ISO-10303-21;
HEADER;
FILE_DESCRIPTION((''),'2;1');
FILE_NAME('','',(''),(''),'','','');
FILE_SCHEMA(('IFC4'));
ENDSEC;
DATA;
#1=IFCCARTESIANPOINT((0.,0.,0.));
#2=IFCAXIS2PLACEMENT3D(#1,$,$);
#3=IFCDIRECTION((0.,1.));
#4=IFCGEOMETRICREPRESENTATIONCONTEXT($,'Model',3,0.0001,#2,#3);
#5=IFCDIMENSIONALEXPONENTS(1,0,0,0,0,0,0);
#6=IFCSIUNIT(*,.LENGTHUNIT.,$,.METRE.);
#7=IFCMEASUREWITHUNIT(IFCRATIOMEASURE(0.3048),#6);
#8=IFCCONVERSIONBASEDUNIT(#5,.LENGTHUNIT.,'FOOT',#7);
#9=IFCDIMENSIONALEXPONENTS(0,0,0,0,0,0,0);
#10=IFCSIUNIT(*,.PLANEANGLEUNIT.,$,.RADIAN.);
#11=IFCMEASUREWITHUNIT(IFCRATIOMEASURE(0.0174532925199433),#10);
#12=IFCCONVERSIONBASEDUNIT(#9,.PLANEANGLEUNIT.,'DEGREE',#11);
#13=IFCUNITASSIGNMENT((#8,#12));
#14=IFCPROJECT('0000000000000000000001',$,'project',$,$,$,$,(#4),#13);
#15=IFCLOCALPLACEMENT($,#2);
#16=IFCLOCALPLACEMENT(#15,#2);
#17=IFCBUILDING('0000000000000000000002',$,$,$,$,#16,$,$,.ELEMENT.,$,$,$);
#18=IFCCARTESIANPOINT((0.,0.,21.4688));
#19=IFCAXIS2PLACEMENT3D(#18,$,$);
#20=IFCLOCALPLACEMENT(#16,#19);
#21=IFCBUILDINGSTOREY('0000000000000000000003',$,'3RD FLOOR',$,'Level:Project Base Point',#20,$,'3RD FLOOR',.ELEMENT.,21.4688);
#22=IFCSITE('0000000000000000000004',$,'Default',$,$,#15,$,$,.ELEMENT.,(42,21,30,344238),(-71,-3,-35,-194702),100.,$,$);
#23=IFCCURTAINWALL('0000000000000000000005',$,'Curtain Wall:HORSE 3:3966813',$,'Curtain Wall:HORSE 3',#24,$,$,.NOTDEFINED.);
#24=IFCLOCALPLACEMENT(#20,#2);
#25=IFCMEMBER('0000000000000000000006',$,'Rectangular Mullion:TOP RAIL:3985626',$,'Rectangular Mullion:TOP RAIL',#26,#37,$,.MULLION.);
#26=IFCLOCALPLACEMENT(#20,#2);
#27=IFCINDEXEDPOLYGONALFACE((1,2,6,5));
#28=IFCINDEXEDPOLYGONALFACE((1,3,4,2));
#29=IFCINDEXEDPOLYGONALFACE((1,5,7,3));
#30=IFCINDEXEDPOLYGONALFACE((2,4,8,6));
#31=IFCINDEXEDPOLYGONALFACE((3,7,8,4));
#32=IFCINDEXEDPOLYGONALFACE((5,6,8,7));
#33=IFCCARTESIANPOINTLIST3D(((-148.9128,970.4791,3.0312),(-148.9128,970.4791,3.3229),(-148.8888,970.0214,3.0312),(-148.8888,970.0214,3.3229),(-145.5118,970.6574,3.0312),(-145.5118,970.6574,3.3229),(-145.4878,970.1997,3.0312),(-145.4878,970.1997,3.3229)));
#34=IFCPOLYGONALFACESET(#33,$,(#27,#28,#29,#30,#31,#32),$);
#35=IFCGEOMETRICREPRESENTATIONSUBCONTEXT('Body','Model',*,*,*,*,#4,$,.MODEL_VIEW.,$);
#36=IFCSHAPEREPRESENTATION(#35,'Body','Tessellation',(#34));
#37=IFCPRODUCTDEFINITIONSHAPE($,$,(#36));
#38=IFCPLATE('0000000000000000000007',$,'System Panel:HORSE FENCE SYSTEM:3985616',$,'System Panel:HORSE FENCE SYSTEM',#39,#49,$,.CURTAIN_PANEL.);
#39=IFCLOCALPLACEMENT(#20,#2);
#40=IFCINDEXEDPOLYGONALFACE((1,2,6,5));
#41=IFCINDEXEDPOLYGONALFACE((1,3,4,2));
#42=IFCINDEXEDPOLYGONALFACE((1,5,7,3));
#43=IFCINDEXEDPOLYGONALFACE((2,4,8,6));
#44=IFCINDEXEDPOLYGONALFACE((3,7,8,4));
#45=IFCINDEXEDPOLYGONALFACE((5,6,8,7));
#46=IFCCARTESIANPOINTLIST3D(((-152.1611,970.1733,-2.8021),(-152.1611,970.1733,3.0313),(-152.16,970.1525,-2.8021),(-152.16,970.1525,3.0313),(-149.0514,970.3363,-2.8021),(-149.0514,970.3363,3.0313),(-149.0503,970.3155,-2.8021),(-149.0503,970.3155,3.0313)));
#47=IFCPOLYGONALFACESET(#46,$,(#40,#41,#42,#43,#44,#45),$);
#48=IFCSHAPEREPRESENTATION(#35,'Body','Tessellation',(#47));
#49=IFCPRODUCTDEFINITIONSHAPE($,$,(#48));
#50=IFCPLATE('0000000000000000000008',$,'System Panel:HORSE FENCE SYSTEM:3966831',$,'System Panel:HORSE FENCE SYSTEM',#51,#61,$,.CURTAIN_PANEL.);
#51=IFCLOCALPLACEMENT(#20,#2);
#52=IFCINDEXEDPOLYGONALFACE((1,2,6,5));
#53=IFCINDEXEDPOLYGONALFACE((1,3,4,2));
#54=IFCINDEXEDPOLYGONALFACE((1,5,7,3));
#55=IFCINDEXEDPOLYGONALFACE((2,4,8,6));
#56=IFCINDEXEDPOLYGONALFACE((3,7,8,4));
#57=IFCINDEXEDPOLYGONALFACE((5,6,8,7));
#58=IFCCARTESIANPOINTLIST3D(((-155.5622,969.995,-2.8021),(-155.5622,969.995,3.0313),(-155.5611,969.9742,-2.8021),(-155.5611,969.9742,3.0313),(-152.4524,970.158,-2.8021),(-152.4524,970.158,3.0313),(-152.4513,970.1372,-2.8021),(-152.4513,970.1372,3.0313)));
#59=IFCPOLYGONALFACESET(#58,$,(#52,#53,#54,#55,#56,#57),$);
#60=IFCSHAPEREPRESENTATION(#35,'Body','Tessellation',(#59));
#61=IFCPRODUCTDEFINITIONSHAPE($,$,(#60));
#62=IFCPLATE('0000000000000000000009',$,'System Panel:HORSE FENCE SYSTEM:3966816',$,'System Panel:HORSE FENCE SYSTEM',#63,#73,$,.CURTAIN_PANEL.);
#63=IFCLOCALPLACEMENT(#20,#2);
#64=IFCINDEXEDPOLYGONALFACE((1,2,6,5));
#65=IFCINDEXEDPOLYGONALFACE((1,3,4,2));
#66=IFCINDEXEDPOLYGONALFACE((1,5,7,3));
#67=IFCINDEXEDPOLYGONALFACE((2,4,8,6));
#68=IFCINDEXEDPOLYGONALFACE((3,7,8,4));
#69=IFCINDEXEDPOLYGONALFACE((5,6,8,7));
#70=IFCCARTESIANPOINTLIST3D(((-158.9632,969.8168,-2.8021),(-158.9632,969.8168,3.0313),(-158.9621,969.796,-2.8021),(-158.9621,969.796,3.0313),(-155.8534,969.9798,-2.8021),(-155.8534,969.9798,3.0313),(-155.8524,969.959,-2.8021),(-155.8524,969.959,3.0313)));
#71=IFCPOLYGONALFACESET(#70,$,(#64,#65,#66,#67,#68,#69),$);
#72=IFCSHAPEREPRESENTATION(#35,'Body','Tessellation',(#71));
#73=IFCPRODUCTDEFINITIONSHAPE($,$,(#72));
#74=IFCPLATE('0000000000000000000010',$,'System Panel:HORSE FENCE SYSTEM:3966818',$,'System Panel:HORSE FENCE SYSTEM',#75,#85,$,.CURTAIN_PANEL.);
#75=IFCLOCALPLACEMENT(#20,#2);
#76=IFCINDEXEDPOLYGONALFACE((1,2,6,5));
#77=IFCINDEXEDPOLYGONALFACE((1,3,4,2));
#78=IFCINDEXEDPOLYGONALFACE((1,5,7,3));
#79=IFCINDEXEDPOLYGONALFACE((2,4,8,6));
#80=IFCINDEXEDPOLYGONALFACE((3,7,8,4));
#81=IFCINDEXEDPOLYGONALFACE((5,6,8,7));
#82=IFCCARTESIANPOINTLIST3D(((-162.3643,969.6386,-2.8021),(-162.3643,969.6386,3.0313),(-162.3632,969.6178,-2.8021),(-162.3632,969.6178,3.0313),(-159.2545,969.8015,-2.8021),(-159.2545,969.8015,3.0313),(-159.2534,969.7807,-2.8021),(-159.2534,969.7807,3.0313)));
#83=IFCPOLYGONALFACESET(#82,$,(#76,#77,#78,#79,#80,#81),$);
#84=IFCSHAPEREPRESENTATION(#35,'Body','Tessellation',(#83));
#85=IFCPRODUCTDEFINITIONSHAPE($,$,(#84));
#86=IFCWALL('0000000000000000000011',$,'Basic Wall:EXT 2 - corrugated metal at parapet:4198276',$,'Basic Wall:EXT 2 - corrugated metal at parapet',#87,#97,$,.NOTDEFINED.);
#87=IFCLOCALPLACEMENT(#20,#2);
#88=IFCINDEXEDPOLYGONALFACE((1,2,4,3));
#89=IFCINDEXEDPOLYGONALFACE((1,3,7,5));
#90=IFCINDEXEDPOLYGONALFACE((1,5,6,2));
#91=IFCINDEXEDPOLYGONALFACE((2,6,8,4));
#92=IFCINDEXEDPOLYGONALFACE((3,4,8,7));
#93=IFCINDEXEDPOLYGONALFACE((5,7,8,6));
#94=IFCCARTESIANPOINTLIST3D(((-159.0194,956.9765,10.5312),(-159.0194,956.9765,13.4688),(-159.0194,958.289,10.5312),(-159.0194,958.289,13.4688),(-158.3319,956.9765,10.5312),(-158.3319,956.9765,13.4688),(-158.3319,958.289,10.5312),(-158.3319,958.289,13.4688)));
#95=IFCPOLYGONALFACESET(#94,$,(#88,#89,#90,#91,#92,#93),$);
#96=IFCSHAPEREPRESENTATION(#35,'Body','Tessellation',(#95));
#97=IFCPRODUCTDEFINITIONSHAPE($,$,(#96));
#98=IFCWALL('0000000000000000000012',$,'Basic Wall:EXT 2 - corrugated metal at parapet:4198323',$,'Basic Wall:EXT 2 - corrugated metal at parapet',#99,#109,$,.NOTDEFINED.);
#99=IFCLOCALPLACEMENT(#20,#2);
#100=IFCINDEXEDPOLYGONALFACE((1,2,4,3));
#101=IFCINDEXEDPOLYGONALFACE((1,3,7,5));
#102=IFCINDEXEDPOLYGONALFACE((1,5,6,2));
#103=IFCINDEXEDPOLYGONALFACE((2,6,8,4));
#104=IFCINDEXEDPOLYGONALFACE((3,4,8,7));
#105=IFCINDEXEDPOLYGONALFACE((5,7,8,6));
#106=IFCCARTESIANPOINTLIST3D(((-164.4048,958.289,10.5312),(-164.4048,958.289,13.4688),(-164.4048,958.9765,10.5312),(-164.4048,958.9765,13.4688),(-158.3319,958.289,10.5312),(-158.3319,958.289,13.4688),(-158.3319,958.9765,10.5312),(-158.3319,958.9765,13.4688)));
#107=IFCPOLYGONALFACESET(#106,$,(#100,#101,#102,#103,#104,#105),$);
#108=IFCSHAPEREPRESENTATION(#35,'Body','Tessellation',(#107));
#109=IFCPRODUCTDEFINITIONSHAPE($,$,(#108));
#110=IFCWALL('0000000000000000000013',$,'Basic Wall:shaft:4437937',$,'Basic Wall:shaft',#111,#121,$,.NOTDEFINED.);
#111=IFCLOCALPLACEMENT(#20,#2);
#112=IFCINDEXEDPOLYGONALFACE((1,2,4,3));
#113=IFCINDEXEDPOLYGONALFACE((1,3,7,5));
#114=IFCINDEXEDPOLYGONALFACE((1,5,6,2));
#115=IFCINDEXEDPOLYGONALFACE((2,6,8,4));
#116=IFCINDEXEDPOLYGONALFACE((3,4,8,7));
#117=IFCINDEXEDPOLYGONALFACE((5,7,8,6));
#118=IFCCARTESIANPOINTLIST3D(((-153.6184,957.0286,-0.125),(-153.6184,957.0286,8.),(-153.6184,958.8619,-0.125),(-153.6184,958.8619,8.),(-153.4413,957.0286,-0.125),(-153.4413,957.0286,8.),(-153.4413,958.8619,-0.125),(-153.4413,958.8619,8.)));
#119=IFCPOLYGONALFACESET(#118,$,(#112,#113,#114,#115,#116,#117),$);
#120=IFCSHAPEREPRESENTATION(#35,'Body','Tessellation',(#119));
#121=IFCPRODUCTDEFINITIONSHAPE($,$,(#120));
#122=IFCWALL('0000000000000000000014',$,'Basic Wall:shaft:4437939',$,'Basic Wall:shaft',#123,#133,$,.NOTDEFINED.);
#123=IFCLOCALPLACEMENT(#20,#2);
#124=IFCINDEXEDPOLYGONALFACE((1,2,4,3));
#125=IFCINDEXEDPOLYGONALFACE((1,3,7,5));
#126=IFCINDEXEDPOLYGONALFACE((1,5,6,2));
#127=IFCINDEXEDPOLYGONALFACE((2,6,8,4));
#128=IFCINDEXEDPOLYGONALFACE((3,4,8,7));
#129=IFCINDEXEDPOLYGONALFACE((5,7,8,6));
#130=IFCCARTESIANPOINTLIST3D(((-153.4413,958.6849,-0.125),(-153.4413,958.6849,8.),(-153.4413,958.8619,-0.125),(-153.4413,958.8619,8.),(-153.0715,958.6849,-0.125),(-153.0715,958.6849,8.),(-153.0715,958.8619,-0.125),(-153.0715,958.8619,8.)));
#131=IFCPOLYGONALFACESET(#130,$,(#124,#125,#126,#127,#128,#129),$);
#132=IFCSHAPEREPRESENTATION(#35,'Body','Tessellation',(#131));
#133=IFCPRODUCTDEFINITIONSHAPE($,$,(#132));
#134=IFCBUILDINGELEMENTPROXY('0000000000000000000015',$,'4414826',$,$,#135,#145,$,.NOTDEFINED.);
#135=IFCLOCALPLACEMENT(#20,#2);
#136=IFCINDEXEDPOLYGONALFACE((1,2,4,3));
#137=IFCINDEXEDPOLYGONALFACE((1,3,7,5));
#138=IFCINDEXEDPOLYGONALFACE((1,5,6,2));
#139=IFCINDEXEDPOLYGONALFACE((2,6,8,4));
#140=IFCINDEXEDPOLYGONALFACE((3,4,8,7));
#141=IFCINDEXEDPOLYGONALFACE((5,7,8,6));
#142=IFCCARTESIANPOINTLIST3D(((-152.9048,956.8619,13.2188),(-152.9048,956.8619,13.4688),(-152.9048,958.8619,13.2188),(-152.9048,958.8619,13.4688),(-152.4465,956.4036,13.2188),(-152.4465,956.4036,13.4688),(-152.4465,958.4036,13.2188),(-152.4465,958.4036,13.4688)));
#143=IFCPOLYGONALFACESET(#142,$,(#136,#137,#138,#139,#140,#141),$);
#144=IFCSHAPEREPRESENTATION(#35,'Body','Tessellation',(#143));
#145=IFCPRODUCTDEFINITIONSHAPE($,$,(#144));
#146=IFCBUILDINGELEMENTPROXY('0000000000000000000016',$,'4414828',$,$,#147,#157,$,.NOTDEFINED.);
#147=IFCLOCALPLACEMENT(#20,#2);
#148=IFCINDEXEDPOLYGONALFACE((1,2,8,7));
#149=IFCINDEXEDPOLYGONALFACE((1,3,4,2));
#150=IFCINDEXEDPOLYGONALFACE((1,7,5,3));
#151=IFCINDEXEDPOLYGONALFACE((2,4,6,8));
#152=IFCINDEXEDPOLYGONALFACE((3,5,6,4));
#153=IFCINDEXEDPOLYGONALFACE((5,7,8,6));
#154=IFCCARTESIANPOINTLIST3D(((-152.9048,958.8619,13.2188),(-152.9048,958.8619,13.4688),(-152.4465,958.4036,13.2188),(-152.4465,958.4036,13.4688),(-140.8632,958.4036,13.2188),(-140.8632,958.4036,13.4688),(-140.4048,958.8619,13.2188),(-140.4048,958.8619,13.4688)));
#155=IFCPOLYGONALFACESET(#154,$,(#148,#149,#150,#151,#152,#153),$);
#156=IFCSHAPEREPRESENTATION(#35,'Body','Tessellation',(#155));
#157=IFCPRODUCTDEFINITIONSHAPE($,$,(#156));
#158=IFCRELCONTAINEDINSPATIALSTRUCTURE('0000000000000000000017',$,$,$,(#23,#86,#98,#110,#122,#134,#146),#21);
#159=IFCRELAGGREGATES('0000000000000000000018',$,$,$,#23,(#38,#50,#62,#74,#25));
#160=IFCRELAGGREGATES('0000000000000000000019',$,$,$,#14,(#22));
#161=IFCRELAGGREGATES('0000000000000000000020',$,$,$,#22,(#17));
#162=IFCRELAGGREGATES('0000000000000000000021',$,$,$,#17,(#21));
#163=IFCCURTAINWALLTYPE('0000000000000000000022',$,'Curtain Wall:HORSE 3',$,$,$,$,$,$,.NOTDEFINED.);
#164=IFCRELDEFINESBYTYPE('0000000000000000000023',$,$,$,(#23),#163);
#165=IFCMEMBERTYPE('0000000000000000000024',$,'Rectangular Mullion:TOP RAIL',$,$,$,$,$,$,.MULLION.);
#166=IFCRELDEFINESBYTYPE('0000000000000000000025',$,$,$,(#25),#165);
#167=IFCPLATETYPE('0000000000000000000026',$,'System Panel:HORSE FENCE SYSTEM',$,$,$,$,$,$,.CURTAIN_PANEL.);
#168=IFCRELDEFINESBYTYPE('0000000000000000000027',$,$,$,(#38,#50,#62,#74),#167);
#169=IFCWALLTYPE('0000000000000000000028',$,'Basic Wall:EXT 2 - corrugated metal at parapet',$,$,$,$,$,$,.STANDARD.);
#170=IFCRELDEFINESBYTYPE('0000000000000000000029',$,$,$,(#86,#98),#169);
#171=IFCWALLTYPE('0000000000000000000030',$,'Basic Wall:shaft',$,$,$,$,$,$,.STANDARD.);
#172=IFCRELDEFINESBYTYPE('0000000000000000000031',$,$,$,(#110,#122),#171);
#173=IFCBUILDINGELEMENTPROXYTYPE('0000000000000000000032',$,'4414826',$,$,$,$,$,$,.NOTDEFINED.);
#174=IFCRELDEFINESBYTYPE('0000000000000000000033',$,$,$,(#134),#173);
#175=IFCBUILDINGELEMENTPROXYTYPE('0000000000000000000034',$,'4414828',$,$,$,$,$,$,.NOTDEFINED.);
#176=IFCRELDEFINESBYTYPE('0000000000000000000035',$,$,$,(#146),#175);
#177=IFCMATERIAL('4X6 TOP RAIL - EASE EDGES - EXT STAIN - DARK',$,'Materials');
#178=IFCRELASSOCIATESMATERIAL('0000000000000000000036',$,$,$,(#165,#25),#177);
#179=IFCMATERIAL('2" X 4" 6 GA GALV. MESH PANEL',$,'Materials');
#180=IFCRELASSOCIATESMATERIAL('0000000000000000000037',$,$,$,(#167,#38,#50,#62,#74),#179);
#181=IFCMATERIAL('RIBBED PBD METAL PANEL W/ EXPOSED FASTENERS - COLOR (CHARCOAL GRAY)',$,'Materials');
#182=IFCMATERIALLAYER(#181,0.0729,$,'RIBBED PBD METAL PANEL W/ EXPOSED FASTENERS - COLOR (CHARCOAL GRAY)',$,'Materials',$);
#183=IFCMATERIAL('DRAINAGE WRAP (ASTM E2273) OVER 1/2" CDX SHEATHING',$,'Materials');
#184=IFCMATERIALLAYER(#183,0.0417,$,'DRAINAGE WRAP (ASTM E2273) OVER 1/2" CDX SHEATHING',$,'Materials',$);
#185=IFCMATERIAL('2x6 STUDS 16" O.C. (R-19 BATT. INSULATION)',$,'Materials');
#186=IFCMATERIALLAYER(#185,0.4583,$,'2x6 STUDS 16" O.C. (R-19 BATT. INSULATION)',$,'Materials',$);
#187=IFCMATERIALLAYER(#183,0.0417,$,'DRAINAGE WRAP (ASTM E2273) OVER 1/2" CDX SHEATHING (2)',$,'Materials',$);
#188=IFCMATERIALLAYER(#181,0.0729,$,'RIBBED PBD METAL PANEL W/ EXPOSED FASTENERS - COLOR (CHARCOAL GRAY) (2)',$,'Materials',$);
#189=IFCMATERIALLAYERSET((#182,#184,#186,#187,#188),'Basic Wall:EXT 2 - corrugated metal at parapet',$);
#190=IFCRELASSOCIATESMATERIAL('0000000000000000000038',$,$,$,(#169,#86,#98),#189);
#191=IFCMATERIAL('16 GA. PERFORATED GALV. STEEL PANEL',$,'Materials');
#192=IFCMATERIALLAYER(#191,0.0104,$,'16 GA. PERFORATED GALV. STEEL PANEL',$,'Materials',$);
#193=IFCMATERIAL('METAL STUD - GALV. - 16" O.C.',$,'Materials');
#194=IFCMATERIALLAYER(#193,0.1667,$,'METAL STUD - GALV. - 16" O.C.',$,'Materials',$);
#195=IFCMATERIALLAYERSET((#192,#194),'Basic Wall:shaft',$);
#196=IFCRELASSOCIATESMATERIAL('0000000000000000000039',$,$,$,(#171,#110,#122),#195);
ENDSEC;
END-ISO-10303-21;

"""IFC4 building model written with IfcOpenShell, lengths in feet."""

from ifc_helpers import new_model, entity, si_unit, converted_unit, direction, frame, frame_2d, origin, origin_2d_with_axis, place, context, subcontext, project, spatial, polyline, rectangle, outline, extrude, source, transform, mapped, material, layer, layer_set, layer_usage, material_profile, profile_set, profile_usage, type_object, type_shapes, element, aggregate, save


model = new_model("IFC4")

# Units and contexts
model_context = context("Model", 3, precision=0.0001, world=origin(), true_north=direction((0.0, 1.0)))
body_context = subcontext(model_context, "Body", "Model", "MODEL_VIEW")
ifc_project = project(units=[converted_unit("LENGTHUNIT", "FOOT", entity("IfcRatioMeasure", 0.3048), si_unit("LENGTHUNIT", "METRE"), dimensions=[1, 0, 0, 0, 0, 0, 0]), converted_unit("PLANEANGLEUNIT", "DEGREE", entity("IfcRatioMeasure", 0.0174532925199433), si_unit("PLANEANGLEUNIT", "RADIAN"), dimensions=[0, 0, 0, 0, 0, 0, 0])], contexts=[model_context])

# Site, building, storey
site_placement = place(None, origin())
site = spatial("IfcSite", under=ifc_project, at=site_placement, Name="Default", CompositionType="ELEMENT", RefLatitude=(42, 21, 30, 344238), RefLongitude=(-71, -3, -35, -194702), RefElevation=100.0)
building_placement = place(site_placement, origin())
building = spatial("IfcBuilding", under=site, at=building_placement, CompositionType="ELEMENT")
storey_placement = place(building_placement, frame((0.0, 0.0, 21.4688)))
storey = spatial("IfcBuildingStorey", under=building, at=storey_placement, Name="3RD FLOOR", ObjectType="Level:Project Base Point", LongName="3RD FLOOR", CompositionType="ELEMENT", Elevation=21.4688)

# Curtain wall
curtain_wall_type_1 = type_object("IfcCurtainWallType", Name="Curtain Wall:HORSE 3", PredefinedType="NOTDEFINED")
curtain_wall_1_placement = place(storey_placement, frame((0.0, 0.0, -21.4688)))
curtain_wall_1 = element("IfcCurtainWall", 1, at=curtain_wall_1_placement, inside=storey, type_object=curtain_wall_type_1, Name="Curtain Wall:HORSE 3:3966813", ObjectType="Curtain Wall:HORSE 3", PredefinedType="NOTDEFINED")

# Member
ifc_material_1 = material(Name="4X6 TOP RAIL - EASE EDGES - EXT STAIN - DARK", Category="Materials")
ifc_material_profile_1 = material_profile(ifc_material_1, rectangle(XDim=0.4583, YDim=0.2917, at=origin_2d_with_axis()), Name="TOP RAIL")
ifc_profile_set_1 = profile_set([ifc_material_profile_1], Name="TOP RAIL")
ifc_profile_usage_1 = profile_usage(ifc_profile_set_1)
member_type_1 = type_object("IfcMemberType", Name="Rectangular Mullion:TOP RAIL", PredefinedType="MULLION", material=ifc_profile_set_1)
shared_shape_1 = source(origin(), body_context, "Body", "SweptSolid", [
    extrude(rectangle(XDim=0.4583, YDim=0.2917, at=origin_2d_with_axis()), frame((-0.1458, 0.0625, -3.4057), z_axis=(0.0, 0.0, 1.0), x_axis=(0.0, -1.0, 0.0)), (0.0, 0.0, 1.0), 3.4057),
])
type_shapes(member_type_1, [shared_shape_1])
member_1_placement = place(storey_placement, frame((-148.8975, 970.1879, 3.3229), z_axis=(-0.99863, -0.052336, 0.0), x_axis=(0.0, 0.0, 1.0)))
member_1 = element("IfcMember", 2, at=member_1_placement, type_object=member_type_1, material=ifc_profile_usage_1, Name="Rectangular Mullion:TOP RAIL:3985626", ObjectType="Rectangular Mullion:TOP RAIL", PredefinedType="MULLION", context=body_context, shape_type="MappedRepresentation", body=[
    mapped(shared_shape_1, transform((0.0, 0.0, 0.0), scale=1.0)),
])

# Plates
ifc_material_2 = material(Name="2\" X 4\" 6 GA GALV. MESH PANEL", Category="Materials")
plate_type = type_object("IfcPlateType", Name="System Panel:HORSE FENCE SYSTEM", PredefinedType="CURTAIN_PANEL", material=ifc_material_2)
shared_shape_2 = source(origin(), body_context, "Body", "SweptSolid", [
    extrude(rectangle(XDim=0.0208, YDim=3.114, at=frame_2d((0.0, 0.0), x_axis=(1.0, 0.0))), frame((1.557, 0.0104, 0.0), z_axis=(0.0, 0.0, 1.0), x_axis=(0.0, 1.0, 0.0)), (0.0, 0.0, 1.0), 5.8333),
])
type_shapes(plate_type, [shared_shape_2])
plate_1_placement = place(curtain_wall_1_placement, frame((-149.0514, 970.3363, 18.6667), z_axis=(0.0, 0.0, 1.0), x_axis=(-0.99863, -0.052336, 0.0)))
plate_1 = element("IfcPlate", 3, at=plate_1_placement, type_object=plate_type, material=ifc_material_2, Name="System Panel:HORSE FENCE SYSTEM:3985616", ObjectType="System Panel:HORSE FENCE SYSTEM", PredefinedType="CURTAIN_PANEL", context=body_context, shape_type="MappedRepresentation", body=[
    mapped(shared_shape_2, transform((0.0, 0.0, 0.0), scale=1.0)),
])
plate_2_placement = place(curtain_wall_1_placement, frame((-152.4524, 970.158, 18.6667), z_axis=(0.0, 0.0, 1.0), x_axis=(-0.99863, -0.052336, 0.0)))
plate_2 = element("IfcPlate", 4, at=plate_2_placement, type_object=plate_type, material=ifc_material_2, Name="System Panel:HORSE FENCE SYSTEM:3966831", ObjectType="System Panel:HORSE FENCE SYSTEM", PredefinedType="CURTAIN_PANEL", context=body_context, shape_type="MappedRepresentation", body=[
    mapped(shared_shape_2, transform((0.0, 0.0, 0.0), scale=1.0)),
])
plate_3_placement = place(curtain_wall_1_placement, frame((-155.8534, 969.9798, 18.6667), z_axis=(0.0, 0.0, 1.0), x_axis=(-0.99863, -0.052336, 0.0)))
plate_3 = element("IfcPlate", 5, at=plate_3_placement, type_object=plate_type, material=ifc_material_2, Name="System Panel:HORSE FENCE SYSTEM:3966816", ObjectType="System Panel:HORSE FENCE SYSTEM", PredefinedType="CURTAIN_PANEL", context=body_context, shape_type="MappedRepresentation", body=[
    mapped(shared_shape_2, transform((0.0, 0.0, 0.0), scale=1.0)),
])
plate_4_placement = place(curtain_wall_1_placement, frame((-159.2545, 969.8015, 18.6667), z_axis=(0.0, 0.0, 1.0), x_axis=(-0.99863, -0.052336, 0.0)))
plate_4 = element("IfcPlate", 6, at=plate_4_placement, type_object=plate_type, material=ifc_material_2, Name="System Panel:HORSE FENCE SYSTEM:3966818", ObjectType="System Panel:HORSE FENCE SYSTEM", PredefinedType="CURTAIN_PANEL", context=body_context, shape_type="MappedRepresentation", body=[
    mapped(shared_shape_2, transform((0.0, 0.0, 0.0), scale=1.0)),
])
aggregate(curtain_wall_1, [plate_1, plate_2, plate_3, plate_4, member_1])

# Walls
ifc_material_3 = material(Name="RIBBED PBD METAL PANEL W/ EXPOSED FASTENERS - COLOR (CHARCOAL GRAY)", Category="Materials")
ifc_layer_1 = layer(ifc_material_3, 0.0729, Name="RIBBED PBD METAL PANEL W/ EXPOSED FASTENERS - COLOR (CHARCOAL GRAY)", Category="Materials")
ifc_material_4 = material(Name="DRAINAGE WRAP (ASTM E2273) OVER 1/2\" CDX SHEATHING", Category="Materials")
ifc_layer_2 = layer(ifc_material_4, 0.0417, Name="DRAINAGE WRAP (ASTM E2273) OVER 1/2\" CDX SHEATHING", Category="Materials")
ifc_material_5 = material(Name="2x6 STUDS 16\" O.C. (R-19 BATT. INSULATION)", Category="Materials")
ifc_layer_3 = layer(ifc_material_5, 0.4583, Name="2x6 STUDS 16\" O.C. (R-19 BATT. INSULATION)", Category="Materials")
ifc_layer_4 = layer(ifc_material_4, 0.0417, Name="DRAINAGE WRAP (ASTM E2273) OVER 1/2\" CDX SHEATHING (2)", Category="Materials")
ifc_layer_5 = layer(ifc_material_3, 0.0729, Name="RIBBED PBD METAL PANEL W/ EXPOSED FASTENERS - COLOR (CHARCOAL GRAY) (2)", Category="Materials")
ifc_layer_set_1 = layer_set([ifc_layer_1, ifc_layer_2, ifc_layer_3, ifc_layer_4, ifc_layer_5], Name="Basic Wall:EXT 2 - corrugated metal at parapet")
ifc_layer_usage_1 = layer_usage(ifc_layer_set_1, "AXIS2", "POSITIVE", -0.3438)
wall_type_1 = type_object("IfcWallType", Name="Basic Wall:EXT 2 - corrugated metal at parapet", PredefinedType="STANDARD", material=ifc_layer_set_1)
wall_1_placement = place(storey_placement, frame((-158.6757, 956.9765, 10.5312), z_axis=(0.0, 0.0, 1.0), x_axis=(0.0, 1.0, 0.0)))
element("IfcWall", 7, at=wall_1_placement, inside=storey, type_object=wall_type_1, material=ifc_layer_usage_1, Name="Basic Wall:EXT 2 - corrugated metal at parapet:4198276", ObjectType="Basic Wall:EXT 2 - corrugated metal at parapet", PredefinedType="NOTDEFINED", context=body_context, shape_type="SweptSolid", body=[
    extrude(rectangle(XDim=1.3125, YDim=0.6875, at=frame_2d((0.6563, 0.0), x_axis=(-1.0, 0.0))), origin(), (0.0, 0.0, 1.0), 2.9375),
])
ifc_layer_usage_2 = layer_usage(ifc_layer_set_1, "AXIS2", "POSITIVE", -0.3438)
wall_2_placement = place(storey_placement, frame((-158.3319, 958.6328, 10.5312), z_axis=(0.0, 0.0, 1.0), x_axis=(-1.0, 0.0, 0.0)))
element("IfcWall", 8, at=wall_2_placement, inside=storey, type_object=wall_type_1, material=ifc_layer_usage_2, Name="Basic Wall:EXT 2 - corrugated metal at parapet:4198323", ObjectType="Basic Wall:EXT 2 - corrugated metal at parapet", PredefinedType="NOTDEFINED", context=body_context, shape_type="SweptSolid", body=[
    extrude(rectangle(XDim=6.0729, YDim=0.6875, at=frame_2d((3.0365, 0.0), x_axis=(-1.0, 0.0))), origin(), (0.0, 0.0, 1.0), 2.9375),
])
ifc_material_6 = material(Name="16 GA. PERFORATED GALV. STEEL PANEL", Category="Materials")
ifc_layer_6 = layer(ifc_material_6, 0.0104, Name="16 GA. PERFORATED GALV. STEEL PANEL", Category="Materials")
ifc_material_7 = material(Name="METAL STUD - GALV. - 16\" O.C.", Category="Materials")
ifc_layer_7 = layer(ifc_material_7, 0.1667, Name="METAL STUD - GALV. - 16\" O.C.", Category="Materials")
ifc_layer_set_2 = layer_set([ifc_layer_6, ifc_layer_7], Name="Basic Wall:shaft")
ifc_layer_usage_3 = layer_usage(ifc_layer_set_2, "AXIS2", "NEGATIVE", 0.0885)
wall_type_2 = type_object("IfcWallType", Name="Basic Wall:shaft", PredefinedType="STANDARD", material=ifc_layer_set_2)
wall_3_placement = place(storey_placement, frame((-153.5298, 957.0286, -0.125), z_axis=(0.0, 0.0, 1.0), x_axis=(0.0, 1.0, 0.0)))
element("IfcWall", 9, at=wall_3_placement, inside=storey, type_object=wall_type_2, material=ifc_layer_usage_3, Name="Basic Wall:shaft:4437937", ObjectType="Basic Wall:shaft", PredefinedType="NOTDEFINED", context=body_context, shape_type="SweptSolid", body=[
    extrude(rectangle(XDim=1.8333, YDim=0.1771, at=frame_2d((0.9167, 0.0), x_axis=(-1.0, 0.0))), origin(), (0.0, 0.0, 1.0), 8.125),
])
ifc_layer_usage_4 = layer_usage(ifc_layer_set_2, "AXIS2", "POSITIVE", -0.0885)
wall_4_placement = place(storey_placement, frame((-153.0715, 958.7734, -0.125), z_axis=(0.0, 0.0, 1.0), x_axis=(-1.0, 0.0, 0.0)))
element("IfcWall", 10, at=wall_4_placement, inside=storey, type_object=wall_type_2, material=ifc_layer_usage_4, Name="Basic Wall:shaft:4437939", ObjectType="Basic Wall:shaft", PredefinedType="NOTDEFINED", context=body_context, shape_type="SweptSolid", body=[
    extrude(rectangle(XDim=0.3698, YDim=0.1771, at=frame_2d((0.1849, 0.0), x_axis=(-1.0, 0.0))), origin(), (0.0, 0.0, 1.0), 8.125),
])

# Building element proxies
building_element_proxy_type_1 = type_object("IfcBuildingElementProxyType", Name="4414826", PredefinedType="NOTDEFINED")
proxy_1_placement = place(storey_placement, frame((-152.9048, 956.4036, 13.2188)))
element("IfcBuildingElementProxy", 11, at=proxy_1_placement, inside=storey, type_object=building_element_proxy_type_1, Name="4414826", PredefinedType="NOTDEFINED", context=body_context, shape_type="SweptSolid", body=[
    extrude(outline(polyline([(-1.2292, -0.2292), (0.7708, -0.2292), (1.2292, 0.2292), (-0.7708, 0.2292), (-1.2292, -0.2292)])), frame((0.2292, 1.2292, 0.0), z_axis=(0.0, 0.0, 1.0), x_axis=(0.0, 1.0, 0.0)), (0.0, 0.0, 1.0), 0.25),
])
building_element_proxy_type_2 = type_object("IfcBuildingElementProxyType", Name="4414828", PredefinedType="NOTDEFINED")
proxy_2_placement = place(storey_placement, frame((-152.9048, 958.4036, 13.2188)))
element("IfcBuildingElementProxy", 12, at=proxy_2_placement, inside=storey, type_object=building_element_proxy_type_2, Name="4414828", PredefinedType="NOTDEFINED", context=body_context, shape_type="SweptSolid", body=[
    extrude(outline(polyline([(-6.25, -0.2292), (6.25, -0.2292), (5.7917, 0.2292), (-5.7917, 0.2292), (-6.25, -0.2292)])), frame((6.25, 0.2292, 0.0), z_axis=(0.0, 0.0, 1.0), x_axis=(-1.0, 0.0, 0.0)), (0.0, 0.0, 1.0), 0.25),
])

save(model, "model.ifc")
